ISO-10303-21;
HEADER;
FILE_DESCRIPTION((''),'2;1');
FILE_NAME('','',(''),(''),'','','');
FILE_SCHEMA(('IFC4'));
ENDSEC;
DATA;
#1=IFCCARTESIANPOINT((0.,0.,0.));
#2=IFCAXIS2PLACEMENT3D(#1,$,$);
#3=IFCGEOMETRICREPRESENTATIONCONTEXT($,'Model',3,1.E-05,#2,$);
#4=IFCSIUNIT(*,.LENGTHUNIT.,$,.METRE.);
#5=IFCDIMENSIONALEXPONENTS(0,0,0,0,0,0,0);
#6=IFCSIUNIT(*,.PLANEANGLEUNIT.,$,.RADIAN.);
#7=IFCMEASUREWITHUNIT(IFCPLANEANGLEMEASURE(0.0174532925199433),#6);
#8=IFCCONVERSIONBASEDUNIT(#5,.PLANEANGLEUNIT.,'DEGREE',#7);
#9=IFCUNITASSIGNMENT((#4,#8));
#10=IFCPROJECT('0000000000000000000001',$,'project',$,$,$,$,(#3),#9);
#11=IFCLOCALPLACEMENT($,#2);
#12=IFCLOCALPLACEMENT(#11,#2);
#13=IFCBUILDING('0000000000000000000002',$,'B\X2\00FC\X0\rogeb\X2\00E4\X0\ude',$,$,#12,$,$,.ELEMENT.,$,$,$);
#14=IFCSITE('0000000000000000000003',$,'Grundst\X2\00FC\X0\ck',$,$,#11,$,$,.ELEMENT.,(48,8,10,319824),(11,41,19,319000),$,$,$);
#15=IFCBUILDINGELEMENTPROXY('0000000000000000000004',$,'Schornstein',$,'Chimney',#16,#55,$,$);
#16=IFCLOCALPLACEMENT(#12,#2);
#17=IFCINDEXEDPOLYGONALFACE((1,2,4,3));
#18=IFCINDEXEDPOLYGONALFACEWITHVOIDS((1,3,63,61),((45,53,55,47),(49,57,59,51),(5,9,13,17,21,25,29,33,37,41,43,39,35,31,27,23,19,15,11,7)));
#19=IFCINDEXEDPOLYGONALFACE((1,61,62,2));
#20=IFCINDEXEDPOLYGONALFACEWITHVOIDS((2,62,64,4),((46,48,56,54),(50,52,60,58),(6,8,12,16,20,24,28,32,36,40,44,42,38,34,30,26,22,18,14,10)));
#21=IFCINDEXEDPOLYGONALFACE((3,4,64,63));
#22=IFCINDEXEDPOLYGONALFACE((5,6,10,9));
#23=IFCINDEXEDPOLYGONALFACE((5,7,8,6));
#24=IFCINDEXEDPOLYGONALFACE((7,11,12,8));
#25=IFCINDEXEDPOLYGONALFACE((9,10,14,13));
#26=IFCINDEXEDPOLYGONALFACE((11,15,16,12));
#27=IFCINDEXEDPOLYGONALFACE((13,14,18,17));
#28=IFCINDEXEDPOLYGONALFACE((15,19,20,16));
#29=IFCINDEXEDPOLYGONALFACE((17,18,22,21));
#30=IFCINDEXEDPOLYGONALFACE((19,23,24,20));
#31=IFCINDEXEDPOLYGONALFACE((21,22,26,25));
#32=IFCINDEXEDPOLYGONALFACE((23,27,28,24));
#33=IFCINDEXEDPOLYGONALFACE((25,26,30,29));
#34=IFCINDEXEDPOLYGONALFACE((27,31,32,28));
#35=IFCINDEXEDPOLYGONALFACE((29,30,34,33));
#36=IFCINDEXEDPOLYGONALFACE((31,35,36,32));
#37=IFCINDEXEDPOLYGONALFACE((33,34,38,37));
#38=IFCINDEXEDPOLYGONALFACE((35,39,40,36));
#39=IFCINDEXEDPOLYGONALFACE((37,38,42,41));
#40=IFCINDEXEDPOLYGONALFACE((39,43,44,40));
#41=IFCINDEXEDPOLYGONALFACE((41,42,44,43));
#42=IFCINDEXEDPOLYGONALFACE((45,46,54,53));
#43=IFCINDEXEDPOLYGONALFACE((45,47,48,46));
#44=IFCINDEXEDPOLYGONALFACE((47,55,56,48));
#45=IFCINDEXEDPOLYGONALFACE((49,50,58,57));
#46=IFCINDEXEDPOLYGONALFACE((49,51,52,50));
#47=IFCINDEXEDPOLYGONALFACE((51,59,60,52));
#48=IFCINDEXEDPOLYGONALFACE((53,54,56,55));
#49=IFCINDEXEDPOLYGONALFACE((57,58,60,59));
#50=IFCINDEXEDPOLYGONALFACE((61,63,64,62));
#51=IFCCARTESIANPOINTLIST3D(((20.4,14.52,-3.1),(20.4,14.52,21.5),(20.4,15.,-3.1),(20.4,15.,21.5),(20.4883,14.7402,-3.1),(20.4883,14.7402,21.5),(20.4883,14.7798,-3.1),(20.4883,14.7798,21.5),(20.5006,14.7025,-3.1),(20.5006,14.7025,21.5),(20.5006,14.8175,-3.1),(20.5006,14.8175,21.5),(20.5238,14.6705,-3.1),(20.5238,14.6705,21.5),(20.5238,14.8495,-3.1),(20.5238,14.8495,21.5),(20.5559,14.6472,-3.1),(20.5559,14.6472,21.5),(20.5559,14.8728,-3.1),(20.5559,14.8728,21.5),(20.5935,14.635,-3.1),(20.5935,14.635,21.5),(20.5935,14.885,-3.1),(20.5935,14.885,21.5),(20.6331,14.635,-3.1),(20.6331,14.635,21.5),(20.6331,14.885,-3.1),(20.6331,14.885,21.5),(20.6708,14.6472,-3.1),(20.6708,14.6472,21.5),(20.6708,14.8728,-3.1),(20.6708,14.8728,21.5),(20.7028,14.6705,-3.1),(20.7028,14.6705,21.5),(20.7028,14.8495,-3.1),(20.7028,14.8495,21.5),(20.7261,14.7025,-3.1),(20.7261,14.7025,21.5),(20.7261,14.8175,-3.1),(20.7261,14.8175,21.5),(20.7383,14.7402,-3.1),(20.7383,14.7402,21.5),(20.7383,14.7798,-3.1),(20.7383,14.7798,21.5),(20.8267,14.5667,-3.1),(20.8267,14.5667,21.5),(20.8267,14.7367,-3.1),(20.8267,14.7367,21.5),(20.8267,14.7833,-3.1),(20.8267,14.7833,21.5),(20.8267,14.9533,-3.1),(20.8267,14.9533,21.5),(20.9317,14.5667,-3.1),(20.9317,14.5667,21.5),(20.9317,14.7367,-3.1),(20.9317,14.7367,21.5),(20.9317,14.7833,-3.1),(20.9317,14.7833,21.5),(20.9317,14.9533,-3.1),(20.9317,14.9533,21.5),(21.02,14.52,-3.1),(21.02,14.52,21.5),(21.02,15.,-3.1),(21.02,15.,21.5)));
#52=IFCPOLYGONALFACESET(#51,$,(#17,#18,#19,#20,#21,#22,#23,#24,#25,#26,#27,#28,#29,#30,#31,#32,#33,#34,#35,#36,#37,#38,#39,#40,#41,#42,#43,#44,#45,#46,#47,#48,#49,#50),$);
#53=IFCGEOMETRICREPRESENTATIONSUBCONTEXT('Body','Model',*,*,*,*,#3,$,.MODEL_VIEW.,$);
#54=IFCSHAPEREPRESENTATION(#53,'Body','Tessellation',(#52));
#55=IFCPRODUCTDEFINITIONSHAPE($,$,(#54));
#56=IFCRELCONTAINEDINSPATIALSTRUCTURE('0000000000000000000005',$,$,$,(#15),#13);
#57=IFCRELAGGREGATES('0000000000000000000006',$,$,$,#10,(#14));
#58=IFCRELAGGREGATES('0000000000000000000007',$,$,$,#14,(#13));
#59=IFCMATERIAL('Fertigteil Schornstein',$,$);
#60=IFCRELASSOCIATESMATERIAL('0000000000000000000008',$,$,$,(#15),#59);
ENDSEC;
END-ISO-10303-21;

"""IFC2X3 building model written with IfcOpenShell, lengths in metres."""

from ifc_helpers import new_model, entity, si_unit, converted_unit, frame, origin, origin_with_axes, place, context, subcontext, project, spatial, polyline, outline, extrude, material, element, save


model = new_model("IFC2X3")

# Units and contexts
model_context = context("Model", 3, precision=1e-05, world=origin())
body_context = subcontext(model_context, "Body", "Model", "MODEL_VIEW")
ifc_project = project(units=[si_unit("LENGTHUNIT", "METRE"), converted_unit("PLANEANGLEUNIT", "DEGREE", entity("IfcPlaneAngleMeasure", 0.0174532925199433), si_unit("PLANEANGLEUNIT", "RADIAN"), dimensions=[0, 0, 0, 0, 0, 0, 0])], contexts=[model_context])

# Site, building
site_placement = place(None, origin())
site = spatial("IfcSite", under=ifc_project, at=site_placement, Name="Grundstück", CompositionType="ELEMENT", RefLatitude=(48, 8, 10, 319824), RefLongitude=(11, 41, 19, 319000))
building_placement = place(site_placement, origin())
building = spatial("IfcBuilding", under=site, at=building_placement, Name="Bürogebäude", CompositionType="ELEMENT")

# Building element proxy
ifc_material = material(Name="Fertigteil Schornstein")
proxy_placement = place(building_placement, frame((20.4, 14.52, -3.1)))
element("IfcBuildingElementProxy", 1, at=proxy_placement, inside=building, material=ifc_material, Name="Schornstein", ObjectType="Chimney", context=body_context, shape_type="SweptSolid", body=[
    extrude(outline(polyline([(0.0, 0.0), (0.62, 0.0), (0.62, 0.48), (0.0, 0.48), (0.0, 0.0)]), holes=[polyline([(0.1935, 0.365), (0.2331, 0.365), (0.2708, 0.3528), (0.3028, 0.3295), (0.3261, 0.2975), (0.3383, 0.2598), (0.3383, 0.2202), (0.3261, 0.1825), (0.3028, 0.1505), (0.2708, 0.1272), (0.2331, 0.115), (0.1935, 0.115), (0.1559, 0.1272), (0.1238, 0.1505), (0.1006, 0.1825), (0.0883, 0.2202), (0.0883, 0.2598), (0.1006, 0.2975), (0.1238, 0.3295), (0.1559, 0.3528), (0.1935, 0.365)]), polyline([(0.4267, 0.0467), (0.4267, 0.2167), (0.5317, 0.2167), (0.5317, 0.0467), (0.4267, 0.0467)]), polyline([(0.4267, 0.2633), (0.4267, 0.4333), (0.5317, 0.4333), (0.5317, 0.2633), (0.4267, 0.2633)])]), origin_with_axes(), (0.0, 0.0, 1.0), 24.6),
])

save(model, "model.ifc")
